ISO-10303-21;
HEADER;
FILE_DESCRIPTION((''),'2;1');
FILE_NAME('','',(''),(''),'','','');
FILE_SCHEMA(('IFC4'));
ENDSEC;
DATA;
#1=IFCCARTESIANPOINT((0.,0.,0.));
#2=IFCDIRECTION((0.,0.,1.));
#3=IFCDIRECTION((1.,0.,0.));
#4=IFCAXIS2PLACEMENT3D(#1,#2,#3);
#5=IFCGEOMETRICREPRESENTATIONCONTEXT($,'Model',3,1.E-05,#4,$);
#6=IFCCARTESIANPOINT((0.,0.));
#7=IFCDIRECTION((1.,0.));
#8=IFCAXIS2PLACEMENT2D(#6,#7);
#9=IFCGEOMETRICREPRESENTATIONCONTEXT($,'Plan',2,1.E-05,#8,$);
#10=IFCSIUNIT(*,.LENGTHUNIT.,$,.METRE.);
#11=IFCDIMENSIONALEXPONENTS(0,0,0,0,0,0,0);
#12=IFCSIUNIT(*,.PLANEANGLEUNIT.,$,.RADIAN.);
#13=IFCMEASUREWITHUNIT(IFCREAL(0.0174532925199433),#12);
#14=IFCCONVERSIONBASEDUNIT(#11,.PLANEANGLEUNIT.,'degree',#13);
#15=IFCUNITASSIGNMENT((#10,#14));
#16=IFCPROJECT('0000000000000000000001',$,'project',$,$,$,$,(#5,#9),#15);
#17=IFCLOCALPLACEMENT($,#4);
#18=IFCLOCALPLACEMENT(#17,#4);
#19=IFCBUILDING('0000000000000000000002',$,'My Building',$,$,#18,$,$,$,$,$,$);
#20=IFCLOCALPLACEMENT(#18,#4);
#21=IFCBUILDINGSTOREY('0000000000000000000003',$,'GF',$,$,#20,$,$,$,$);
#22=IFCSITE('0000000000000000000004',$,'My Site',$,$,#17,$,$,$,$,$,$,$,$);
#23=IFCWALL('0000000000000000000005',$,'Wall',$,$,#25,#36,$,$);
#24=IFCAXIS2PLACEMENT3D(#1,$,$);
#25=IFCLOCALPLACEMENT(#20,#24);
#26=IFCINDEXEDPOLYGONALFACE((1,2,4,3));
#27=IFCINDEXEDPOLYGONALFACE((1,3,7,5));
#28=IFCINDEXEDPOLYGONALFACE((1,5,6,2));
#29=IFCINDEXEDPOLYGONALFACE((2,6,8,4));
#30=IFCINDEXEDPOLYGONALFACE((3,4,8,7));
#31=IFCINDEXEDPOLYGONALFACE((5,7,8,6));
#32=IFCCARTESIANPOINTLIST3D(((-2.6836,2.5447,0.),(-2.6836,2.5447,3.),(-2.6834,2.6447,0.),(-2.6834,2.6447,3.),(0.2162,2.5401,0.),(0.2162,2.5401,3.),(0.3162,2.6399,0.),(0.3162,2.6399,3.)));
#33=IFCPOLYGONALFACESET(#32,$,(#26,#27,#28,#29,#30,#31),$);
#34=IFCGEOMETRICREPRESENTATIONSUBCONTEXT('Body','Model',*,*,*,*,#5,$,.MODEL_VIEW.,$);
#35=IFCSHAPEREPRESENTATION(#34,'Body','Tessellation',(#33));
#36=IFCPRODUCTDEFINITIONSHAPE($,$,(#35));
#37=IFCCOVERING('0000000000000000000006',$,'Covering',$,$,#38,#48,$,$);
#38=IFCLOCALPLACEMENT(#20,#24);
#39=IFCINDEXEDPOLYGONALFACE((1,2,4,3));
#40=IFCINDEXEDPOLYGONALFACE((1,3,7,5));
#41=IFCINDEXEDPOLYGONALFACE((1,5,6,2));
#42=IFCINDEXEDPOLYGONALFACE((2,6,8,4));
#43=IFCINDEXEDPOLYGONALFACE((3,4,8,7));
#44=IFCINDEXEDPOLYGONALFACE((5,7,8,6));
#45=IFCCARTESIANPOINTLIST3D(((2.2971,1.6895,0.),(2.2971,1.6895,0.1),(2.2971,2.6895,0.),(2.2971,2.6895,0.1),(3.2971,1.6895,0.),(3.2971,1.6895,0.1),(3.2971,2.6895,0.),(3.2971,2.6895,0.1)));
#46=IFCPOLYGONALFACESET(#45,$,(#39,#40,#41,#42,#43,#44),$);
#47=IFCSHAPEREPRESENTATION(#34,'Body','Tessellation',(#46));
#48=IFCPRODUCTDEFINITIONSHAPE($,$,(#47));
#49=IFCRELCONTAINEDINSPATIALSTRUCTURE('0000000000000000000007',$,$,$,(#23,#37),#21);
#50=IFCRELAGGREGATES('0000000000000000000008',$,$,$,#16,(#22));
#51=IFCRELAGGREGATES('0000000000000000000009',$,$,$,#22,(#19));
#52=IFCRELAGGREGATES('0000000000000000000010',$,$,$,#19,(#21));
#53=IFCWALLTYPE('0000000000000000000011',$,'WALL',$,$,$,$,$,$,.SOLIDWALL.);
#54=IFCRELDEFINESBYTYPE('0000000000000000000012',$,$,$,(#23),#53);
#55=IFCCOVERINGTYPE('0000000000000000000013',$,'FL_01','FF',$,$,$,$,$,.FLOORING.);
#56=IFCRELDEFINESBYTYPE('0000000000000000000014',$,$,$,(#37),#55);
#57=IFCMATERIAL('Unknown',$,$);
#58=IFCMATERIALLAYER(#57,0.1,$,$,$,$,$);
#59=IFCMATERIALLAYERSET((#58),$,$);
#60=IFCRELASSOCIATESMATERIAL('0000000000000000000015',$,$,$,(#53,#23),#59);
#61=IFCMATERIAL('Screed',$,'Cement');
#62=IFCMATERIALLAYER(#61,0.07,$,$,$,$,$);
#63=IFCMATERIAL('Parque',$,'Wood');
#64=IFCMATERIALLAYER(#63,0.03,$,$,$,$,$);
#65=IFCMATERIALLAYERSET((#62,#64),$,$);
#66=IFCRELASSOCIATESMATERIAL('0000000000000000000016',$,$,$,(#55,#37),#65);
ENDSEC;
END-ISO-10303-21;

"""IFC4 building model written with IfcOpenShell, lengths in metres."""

from ifc_helpers import new_model, entity, si_unit, converted_unit, frame, origin_with_axes, origin_2d_with_axis, place, context, subcontext, project, spatial, line, indexed_curve, outline, extrude, material, layer, layer_set, layer_usage, type_object, element, save


model = new_model("IFC4")

# Units and contexts
model_context = context("Model", 3, precision=1e-05, world=origin_with_axes())
plan_context = context("Plan", 2, precision=1e-05, world=origin_2d_with_axis())
body_context_1 = subcontext(model_context, "Body", "Model", "MODEL_VIEW")
ifc_project = project(units=[si_unit("LENGTHUNIT", "METRE"), converted_unit("PLANEANGLEUNIT", "degree", entity("IfcReal", 0.0174532925199433), si_unit("PLANEANGLEUNIT", "RADIAN"), dimensions=[0, 0, 0, 0, 0, 0, 0])], contexts=[model_context, plan_context])

# Site, building, storey
site_placement = place(None, origin_with_axes())
site = spatial("IfcSite", under=ifc_project, at=site_placement, Name="My Site")
building_placement = place(site_placement, origin_with_axes())
building = spatial("IfcBuilding", under=site, at=building_placement, Name="My Building")
storey_placement = place(building_placement, origin_with_axes())
storey = spatial("IfcBuildingStorey", under=building, at=storey_placement, Name="GF")

# Shared definitions
ifc_material_1 = material(Name="Unknown")

# Shared definitions
ifc_layer_1 = layer(ifc_material_1, 0.1)
ifc_layer_set_1 = layer_set([ifc_layer_1])
wall_type = type_object("IfcWallType", Name="WALL", PredefinedType="SOLIDWALL", material=ifc_layer_set_1)

# Wall
ifc_layer_usage_1 = layer_usage(ifc_layer_set_1, "AXIS2", "POSITIVE", 0.0)
wall_1_placement = place(storey_placement, frame((0.3162, 2.6399, 0.0), z_axis=(0.0, 0.0, 1.0), x_axis=(-0.999999, 0.001594, 0.0)))
element("IfcWall", 1, at=wall_1_placement, inside=storey, type_object=wall_type, material=ifc_layer_usage_1, Name="Wall", context=body_context_1, shape_type="SweptSolid", body=[
    extrude(outline(indexed_curve([(0.0, 0.0), (0.0998, 0.1), (2.9996, 0.1), (2.9996, 0.0)], segments=[line(1, 2, 3, 4, 1)])), origin_with_axes(), (0.0, 0.0, 1.0), 3.0),
])

# Covering
ifc_material_2 = material(Name="Screed", Category="Cement")
ifc_layer_2 = layer(ifc_material_2, 0.07)
ifc_material_3 = material(Name="Parque", Category="Wood")
ifc_layer_3 = layer(ifc_material_3, 0.03)
ifc_layer_set_2 = layer_set([ifc_layer_2, ifc_layer_3])
ifc_layer_usage_2 = layer_usage(ifc_layer_set_2, "AXIS3", "POSITIVE", 0.0)
covering_type = type_object("IfcCoveringType", Name="FL_01", Description="FF", PredefinedType="FLOORING", material=ifc_layer_set_2)
covering_placement = place(storey_placement, frame((2.2971, 1.6895, 0.0), z_axis=(0.0, 0.0, 1.0), x_axis=(1.0, 0.0, 0.0)))
element("IfcCovering", 2, at=covering_placement, inside=storey, type_object=covering_type, material=ifc_layer_usage_2, Name="Covering", context=body_context_1, shape_type="SweptSolid", body=[
    extrude(outline(indexed_curve([(0.0, 0.0), (1.0, 0.0), (1.0, 1.0), (0.0, 1.0), (0.0, 0.0)])), None, (0.0, 0.0, 1.0), 0.1),
])

save(model, "model.ifc")
